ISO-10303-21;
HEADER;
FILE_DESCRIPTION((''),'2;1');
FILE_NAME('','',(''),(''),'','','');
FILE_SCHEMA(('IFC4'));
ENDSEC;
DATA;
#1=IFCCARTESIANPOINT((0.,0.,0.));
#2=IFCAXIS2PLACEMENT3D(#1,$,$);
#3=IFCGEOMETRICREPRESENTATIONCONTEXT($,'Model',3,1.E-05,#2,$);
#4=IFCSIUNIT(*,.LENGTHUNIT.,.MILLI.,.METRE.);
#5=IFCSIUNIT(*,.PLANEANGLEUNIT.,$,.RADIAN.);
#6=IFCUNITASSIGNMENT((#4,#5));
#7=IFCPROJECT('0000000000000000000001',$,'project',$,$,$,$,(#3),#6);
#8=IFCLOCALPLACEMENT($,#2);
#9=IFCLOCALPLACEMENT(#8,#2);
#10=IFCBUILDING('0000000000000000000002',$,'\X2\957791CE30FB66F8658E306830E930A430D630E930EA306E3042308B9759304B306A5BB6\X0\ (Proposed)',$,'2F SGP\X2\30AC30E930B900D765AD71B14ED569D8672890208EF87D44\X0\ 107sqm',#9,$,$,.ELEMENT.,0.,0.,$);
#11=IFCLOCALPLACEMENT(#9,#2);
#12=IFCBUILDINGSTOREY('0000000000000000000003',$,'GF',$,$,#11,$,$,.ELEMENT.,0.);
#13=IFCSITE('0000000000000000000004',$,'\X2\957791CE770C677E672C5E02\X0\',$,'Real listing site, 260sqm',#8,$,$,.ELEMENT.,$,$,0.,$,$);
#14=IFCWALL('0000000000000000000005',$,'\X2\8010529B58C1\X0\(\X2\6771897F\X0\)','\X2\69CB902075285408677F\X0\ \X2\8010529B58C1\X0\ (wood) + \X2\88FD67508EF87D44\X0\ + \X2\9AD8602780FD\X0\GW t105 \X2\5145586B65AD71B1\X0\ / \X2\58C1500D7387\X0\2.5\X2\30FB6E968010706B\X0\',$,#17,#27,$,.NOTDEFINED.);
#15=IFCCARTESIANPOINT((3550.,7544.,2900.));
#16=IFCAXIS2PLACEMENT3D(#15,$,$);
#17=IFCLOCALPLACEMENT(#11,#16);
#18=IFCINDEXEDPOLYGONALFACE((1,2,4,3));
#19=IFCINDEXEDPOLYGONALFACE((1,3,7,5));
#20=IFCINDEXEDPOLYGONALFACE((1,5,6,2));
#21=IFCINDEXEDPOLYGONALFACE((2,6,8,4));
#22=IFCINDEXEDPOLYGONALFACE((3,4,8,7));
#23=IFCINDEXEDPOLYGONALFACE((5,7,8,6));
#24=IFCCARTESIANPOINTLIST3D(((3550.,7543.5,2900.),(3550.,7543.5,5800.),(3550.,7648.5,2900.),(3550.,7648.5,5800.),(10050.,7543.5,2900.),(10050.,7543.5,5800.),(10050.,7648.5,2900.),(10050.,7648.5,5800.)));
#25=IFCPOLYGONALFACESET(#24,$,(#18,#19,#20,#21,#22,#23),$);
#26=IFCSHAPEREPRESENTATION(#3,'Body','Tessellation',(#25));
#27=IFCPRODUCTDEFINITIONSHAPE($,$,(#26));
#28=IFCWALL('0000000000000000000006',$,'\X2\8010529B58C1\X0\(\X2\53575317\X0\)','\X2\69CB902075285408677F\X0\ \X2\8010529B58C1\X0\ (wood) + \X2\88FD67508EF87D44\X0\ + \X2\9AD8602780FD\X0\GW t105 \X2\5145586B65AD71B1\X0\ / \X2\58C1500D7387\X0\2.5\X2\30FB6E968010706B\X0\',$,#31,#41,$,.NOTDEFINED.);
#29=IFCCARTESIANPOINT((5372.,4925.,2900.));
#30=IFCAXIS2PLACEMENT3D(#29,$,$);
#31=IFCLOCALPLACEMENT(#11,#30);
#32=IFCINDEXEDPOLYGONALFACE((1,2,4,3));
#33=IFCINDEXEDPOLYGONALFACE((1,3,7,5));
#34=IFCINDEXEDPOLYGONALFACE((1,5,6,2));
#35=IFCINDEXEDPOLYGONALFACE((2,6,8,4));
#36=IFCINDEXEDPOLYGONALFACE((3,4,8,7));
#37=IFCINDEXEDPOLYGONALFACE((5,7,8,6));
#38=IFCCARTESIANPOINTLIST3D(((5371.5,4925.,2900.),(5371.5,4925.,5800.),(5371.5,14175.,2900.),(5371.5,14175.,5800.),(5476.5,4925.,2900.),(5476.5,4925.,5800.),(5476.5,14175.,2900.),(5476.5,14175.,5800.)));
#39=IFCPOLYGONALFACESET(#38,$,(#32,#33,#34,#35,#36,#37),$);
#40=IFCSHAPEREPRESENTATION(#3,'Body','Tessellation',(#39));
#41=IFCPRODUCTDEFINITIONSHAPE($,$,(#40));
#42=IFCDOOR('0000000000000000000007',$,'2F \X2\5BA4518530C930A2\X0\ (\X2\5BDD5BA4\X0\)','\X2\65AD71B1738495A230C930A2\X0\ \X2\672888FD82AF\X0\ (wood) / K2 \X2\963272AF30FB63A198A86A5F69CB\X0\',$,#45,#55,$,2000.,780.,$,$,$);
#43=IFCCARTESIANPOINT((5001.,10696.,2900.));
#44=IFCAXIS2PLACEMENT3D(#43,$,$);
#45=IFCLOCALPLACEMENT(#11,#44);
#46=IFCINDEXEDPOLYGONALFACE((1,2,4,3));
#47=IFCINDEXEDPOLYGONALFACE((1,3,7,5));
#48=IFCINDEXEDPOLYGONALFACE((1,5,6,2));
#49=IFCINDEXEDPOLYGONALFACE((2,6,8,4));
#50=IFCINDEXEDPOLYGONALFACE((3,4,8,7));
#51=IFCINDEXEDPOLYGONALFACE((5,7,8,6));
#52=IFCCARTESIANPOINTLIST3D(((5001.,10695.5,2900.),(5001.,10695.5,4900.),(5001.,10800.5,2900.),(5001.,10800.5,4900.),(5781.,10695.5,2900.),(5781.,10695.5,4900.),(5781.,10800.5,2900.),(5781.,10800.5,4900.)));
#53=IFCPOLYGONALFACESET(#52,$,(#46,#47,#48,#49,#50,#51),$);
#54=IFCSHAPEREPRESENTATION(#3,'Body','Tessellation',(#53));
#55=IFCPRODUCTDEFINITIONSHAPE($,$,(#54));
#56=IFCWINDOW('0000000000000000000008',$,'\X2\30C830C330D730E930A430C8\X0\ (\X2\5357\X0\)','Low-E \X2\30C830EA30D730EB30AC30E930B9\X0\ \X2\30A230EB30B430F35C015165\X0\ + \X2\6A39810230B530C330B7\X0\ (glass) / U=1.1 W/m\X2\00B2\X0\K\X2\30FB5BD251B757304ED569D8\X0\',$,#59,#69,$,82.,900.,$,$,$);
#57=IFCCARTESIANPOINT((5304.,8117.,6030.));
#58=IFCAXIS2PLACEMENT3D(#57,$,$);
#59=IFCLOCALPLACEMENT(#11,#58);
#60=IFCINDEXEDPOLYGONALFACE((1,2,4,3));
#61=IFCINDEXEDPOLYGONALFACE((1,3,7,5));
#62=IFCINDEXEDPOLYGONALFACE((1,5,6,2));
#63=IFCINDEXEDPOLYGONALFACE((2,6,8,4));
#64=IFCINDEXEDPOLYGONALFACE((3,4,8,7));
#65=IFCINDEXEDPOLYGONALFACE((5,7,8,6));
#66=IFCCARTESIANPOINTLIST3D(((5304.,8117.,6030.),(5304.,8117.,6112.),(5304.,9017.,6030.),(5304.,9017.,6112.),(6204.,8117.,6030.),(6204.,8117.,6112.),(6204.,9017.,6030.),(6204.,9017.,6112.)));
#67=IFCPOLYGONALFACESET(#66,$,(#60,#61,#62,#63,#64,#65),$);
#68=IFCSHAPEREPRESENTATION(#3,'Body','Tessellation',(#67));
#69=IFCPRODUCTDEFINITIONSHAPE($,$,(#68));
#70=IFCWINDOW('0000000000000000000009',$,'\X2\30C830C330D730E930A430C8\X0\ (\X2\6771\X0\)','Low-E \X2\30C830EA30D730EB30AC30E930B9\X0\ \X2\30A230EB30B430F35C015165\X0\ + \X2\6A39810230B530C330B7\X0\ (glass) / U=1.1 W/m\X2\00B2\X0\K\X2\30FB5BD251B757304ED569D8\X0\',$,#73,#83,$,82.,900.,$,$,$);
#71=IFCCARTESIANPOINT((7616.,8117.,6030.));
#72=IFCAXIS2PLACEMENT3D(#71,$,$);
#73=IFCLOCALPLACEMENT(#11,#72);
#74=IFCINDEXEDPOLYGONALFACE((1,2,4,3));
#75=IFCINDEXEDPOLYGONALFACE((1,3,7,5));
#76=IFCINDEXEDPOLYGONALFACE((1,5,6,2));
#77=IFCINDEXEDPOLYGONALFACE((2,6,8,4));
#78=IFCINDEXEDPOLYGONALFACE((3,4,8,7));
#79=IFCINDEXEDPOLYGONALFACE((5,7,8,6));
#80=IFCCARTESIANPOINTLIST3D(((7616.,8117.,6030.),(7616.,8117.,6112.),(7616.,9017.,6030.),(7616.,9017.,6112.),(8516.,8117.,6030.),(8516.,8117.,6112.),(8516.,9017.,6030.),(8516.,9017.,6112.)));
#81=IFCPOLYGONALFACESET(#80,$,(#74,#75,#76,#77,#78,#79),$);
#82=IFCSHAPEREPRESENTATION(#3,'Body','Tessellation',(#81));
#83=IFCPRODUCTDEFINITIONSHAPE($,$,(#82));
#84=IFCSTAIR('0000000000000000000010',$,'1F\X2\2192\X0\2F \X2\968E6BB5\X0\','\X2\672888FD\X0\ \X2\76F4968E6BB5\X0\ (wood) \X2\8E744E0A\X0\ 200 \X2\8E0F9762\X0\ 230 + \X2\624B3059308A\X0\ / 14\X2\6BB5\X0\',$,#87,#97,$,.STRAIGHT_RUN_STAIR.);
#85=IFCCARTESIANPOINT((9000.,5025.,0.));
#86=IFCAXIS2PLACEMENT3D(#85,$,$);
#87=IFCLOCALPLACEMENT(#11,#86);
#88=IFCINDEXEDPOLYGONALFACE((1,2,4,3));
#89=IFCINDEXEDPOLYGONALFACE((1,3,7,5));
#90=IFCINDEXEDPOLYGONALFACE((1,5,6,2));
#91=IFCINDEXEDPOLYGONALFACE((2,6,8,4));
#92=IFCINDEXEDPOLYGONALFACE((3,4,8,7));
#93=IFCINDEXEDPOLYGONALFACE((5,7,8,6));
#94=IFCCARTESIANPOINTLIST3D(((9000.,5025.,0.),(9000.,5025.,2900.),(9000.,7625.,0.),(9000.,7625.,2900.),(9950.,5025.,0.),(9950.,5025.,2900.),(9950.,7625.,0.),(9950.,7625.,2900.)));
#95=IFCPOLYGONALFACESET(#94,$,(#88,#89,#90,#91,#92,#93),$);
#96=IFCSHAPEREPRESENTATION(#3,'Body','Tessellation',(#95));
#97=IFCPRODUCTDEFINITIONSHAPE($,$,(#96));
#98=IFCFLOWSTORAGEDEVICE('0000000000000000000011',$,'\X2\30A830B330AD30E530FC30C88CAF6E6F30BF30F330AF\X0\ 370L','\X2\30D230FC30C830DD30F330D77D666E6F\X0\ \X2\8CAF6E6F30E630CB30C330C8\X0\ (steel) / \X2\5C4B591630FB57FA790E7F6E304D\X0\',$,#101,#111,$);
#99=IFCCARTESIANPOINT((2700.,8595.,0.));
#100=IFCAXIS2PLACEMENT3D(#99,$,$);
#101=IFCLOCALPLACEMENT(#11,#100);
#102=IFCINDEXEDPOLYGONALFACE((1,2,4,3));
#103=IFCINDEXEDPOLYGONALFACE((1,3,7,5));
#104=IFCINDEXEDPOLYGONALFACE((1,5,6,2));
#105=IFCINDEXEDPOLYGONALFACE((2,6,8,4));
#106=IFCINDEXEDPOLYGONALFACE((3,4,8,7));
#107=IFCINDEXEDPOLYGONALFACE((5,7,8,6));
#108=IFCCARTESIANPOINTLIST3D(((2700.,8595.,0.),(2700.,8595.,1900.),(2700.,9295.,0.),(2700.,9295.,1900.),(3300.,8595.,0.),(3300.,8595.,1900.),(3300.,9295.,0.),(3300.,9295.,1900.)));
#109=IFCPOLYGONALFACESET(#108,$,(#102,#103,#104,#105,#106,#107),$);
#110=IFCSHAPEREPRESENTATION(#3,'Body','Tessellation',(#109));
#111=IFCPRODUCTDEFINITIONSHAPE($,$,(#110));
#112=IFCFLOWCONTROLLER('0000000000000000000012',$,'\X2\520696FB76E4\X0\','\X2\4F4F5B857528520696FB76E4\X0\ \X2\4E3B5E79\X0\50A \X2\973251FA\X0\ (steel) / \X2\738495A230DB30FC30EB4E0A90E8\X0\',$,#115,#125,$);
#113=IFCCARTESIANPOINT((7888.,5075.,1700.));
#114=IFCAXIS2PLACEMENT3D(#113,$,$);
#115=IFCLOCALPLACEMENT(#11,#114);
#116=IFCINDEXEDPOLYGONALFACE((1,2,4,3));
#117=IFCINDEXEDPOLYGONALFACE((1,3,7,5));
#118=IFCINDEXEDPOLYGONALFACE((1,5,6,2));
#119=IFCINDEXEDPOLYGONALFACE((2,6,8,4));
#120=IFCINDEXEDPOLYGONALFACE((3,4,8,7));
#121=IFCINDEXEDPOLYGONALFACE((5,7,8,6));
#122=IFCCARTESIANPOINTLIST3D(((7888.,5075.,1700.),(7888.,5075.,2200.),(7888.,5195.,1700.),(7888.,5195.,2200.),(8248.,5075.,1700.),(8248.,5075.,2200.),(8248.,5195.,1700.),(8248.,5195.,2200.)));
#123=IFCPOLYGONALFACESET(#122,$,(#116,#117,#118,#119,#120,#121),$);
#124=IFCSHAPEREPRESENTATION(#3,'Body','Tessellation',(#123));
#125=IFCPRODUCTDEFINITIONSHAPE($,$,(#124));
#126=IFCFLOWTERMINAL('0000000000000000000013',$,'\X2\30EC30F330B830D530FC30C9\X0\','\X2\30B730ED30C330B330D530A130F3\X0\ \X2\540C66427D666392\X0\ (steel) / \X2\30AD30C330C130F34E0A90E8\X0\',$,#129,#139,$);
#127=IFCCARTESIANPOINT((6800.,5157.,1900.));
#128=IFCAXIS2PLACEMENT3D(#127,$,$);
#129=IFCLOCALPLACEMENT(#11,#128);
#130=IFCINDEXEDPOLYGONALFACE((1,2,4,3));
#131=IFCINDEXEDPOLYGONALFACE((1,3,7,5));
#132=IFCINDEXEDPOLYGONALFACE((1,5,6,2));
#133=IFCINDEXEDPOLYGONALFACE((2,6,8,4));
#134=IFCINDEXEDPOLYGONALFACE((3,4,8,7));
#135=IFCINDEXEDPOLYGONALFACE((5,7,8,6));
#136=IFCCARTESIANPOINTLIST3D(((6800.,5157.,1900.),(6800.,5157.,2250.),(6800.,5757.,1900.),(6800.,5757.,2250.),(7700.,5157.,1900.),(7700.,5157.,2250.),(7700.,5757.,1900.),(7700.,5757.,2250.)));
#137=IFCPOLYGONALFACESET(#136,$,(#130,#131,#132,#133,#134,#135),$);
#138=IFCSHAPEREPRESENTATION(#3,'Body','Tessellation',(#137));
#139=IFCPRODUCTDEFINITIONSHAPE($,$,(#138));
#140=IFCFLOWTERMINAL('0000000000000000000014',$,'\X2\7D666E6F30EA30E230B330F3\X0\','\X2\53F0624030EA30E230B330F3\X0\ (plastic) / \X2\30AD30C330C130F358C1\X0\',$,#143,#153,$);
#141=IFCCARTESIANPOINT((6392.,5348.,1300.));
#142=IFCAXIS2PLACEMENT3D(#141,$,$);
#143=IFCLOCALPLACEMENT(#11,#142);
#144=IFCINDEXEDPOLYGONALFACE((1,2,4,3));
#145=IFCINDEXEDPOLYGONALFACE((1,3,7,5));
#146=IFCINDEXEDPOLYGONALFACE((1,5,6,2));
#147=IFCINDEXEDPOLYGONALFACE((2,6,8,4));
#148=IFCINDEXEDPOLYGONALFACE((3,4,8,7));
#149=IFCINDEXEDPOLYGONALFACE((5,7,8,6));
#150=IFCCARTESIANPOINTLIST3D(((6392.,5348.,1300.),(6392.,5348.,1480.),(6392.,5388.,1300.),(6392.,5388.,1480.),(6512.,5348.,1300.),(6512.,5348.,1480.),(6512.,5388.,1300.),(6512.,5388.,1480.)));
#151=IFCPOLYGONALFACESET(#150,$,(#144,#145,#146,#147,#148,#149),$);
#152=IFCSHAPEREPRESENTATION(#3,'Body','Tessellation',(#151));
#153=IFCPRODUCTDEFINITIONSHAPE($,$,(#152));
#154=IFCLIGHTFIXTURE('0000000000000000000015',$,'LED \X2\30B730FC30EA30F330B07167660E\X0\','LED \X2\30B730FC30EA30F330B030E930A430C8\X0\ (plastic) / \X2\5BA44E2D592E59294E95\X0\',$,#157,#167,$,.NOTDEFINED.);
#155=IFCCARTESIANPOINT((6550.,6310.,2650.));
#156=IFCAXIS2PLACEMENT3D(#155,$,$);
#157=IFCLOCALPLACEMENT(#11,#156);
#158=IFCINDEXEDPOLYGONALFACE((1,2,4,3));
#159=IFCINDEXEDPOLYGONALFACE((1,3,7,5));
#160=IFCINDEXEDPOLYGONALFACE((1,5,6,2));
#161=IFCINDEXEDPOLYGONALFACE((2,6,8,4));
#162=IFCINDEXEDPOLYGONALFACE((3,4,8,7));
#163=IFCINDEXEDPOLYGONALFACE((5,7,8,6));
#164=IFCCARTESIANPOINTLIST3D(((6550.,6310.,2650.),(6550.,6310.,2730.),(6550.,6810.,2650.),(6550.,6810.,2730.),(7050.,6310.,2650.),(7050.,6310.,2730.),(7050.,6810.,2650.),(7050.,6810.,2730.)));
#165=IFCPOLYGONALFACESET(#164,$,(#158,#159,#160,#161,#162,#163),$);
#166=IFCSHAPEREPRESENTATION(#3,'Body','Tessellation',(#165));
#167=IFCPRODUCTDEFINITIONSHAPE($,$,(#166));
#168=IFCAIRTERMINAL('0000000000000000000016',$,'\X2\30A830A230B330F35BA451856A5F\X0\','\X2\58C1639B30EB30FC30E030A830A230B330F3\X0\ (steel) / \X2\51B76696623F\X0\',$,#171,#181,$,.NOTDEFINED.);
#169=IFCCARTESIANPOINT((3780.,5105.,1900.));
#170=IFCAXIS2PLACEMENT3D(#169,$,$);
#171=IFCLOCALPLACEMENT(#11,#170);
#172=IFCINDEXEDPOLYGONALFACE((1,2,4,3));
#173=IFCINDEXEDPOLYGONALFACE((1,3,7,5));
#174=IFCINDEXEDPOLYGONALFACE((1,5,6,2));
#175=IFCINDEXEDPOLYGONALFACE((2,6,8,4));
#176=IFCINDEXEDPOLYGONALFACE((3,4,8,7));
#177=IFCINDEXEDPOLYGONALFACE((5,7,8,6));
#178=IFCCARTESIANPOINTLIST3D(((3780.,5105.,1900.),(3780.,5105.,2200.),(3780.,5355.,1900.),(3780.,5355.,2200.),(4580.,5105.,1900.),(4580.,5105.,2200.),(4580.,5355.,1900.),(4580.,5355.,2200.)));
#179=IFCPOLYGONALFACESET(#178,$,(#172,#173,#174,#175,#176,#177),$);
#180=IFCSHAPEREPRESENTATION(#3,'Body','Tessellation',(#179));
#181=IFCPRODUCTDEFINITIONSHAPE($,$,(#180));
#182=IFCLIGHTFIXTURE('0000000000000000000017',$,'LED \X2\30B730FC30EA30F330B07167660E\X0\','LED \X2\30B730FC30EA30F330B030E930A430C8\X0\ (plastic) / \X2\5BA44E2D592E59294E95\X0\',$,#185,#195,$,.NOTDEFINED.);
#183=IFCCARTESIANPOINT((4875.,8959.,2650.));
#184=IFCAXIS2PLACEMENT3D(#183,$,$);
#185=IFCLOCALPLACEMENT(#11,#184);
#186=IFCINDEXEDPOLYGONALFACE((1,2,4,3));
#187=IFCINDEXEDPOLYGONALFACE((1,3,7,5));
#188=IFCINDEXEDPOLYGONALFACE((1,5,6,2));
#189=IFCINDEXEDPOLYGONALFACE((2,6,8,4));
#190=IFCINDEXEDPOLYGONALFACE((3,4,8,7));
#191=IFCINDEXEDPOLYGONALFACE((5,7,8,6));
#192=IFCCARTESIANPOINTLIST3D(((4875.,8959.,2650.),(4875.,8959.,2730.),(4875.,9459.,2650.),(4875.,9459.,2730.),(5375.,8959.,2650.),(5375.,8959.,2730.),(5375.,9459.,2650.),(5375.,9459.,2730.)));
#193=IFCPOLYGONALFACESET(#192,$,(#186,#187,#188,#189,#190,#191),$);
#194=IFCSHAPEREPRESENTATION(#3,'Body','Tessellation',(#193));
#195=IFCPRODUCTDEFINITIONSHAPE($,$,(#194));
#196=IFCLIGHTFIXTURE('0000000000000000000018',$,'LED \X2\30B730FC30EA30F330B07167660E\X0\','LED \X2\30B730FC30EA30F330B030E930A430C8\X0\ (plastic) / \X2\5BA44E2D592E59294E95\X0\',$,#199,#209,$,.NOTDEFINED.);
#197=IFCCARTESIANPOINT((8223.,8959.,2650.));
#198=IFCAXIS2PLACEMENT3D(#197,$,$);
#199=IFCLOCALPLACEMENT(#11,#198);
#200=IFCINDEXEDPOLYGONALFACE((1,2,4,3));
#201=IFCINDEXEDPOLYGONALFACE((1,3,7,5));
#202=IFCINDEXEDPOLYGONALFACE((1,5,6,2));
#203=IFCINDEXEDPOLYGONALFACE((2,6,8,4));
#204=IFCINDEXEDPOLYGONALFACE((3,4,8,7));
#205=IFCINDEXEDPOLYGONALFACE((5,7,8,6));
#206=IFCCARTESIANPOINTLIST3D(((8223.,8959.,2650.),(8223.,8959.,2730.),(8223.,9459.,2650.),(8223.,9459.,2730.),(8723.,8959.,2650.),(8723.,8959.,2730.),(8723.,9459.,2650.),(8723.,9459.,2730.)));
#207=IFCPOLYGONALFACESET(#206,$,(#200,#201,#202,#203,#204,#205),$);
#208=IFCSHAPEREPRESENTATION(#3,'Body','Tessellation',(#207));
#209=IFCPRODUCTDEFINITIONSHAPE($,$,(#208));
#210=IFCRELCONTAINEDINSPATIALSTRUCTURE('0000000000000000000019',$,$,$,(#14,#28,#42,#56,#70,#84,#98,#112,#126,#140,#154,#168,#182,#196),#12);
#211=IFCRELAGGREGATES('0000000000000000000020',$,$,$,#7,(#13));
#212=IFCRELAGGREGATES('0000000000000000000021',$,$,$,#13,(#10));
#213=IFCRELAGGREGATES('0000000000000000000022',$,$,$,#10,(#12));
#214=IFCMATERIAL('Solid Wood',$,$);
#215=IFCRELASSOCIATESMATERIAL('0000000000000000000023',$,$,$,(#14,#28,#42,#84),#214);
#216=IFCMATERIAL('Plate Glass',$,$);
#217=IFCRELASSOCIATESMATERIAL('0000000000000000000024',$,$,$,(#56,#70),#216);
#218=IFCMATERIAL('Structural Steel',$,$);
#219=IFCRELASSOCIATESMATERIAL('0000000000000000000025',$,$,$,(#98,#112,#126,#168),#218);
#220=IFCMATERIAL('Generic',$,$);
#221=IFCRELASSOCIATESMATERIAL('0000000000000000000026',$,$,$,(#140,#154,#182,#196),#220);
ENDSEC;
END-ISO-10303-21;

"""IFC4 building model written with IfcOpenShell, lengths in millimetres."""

from ifc_helpers import new_model, si_unit, frame, frame_2d, origin, place, context, project, spatial, rectangle, extrude, material, element, fill, save


model = new_model("IFC4")

# Units and contexts
model_context = context("Model", 3, precision=1e-05, world=origin())
ifc_project = project(units=[si_unit("LENGTHUNIT", "METRE", prefix="MILLI"), si_unit("PLANEANGLEUNIT", "RADIAN")], contexts=[model_context])

# Site, building, storey
site_placement = place(None, origin())
site = spatial("IfcSite", under=ifc_project, at=site_placement, Name="長野県松本市", ObjectType="Real listing site, 260sqm", CompositionType="ELEMENT", RefElevation=0.0)
building_placement = place(site_placement, origin())
building = spatial("IfcBuilding", under=site, at=building_placement, Name="長野・書斎とライブラリのある静かな家 (Proposed)", ObjectType="2F SGPガラス×断熱仕様木造軸組 107sqm", CompositionType="ELEMENT", ElevationOfRefHeight=0.0, ElevationOfTerrain=0.0)
storey_placement = place(building_placement, origin())
storey = spatial("IfcBuildingStorey", under=building, at=storey_placement, Name="GF", CompositionType="ELEMENT", Elevation=0.0)

# Shared definitions
ifc_material_1 = material(Name="Solid Wood")

# Wall
wall_1_placement = place(storey_placement, frame((3550.0, 7544.0, 2900.0)))
element("IfcWall", 1, at=wall_1_placement, inside=storey, material=ifc_material_1, Name="耐力壁(東西)", Description="構造用合板 耐力壁 (wood) + 製材軸組 + 高性能GW t105 充填断熱 / 壁倍率2.5・準耐火", PredefinedType="NOTDEFINED", context=model_context, shape_type="SweptSolid", body=[
    extrude(rectangle(XDim=6500.0, YDim=105.0, at=frame_2d((3250.0, 52.0))), frame((3550.0, 7544.0, 2900.0)), (0.0, 0.0, 1.0), 2900.0),
])

# Wall, opening, door
wall_2_placement = place(storey_placement, frame((5372.0, 4925.0, 2900.0)))
wall_2 = element("IfcWall", 2, at=wall_2_placement, inside=storey, material=ifc_material_1, Name="耐力壁(南北)", Description="構造用合板 耐力壁 (wood) + 製材軸組 + 高性能GW t105 充填断熱 / 壁倍率2.5・準耐火", PredefinedType="NOTDEFINED", context=model_context, shape_type="SweptSolid", body=[
    extrude(rectangle(XDim=105.0, YDim=9250.0, at=frame_2d((52.0, 4625.0))), frame((5372.0, 4925.0, 2900.0)), (0.0, 0.0, 1.0), 2900.0),
])
opening_placement = place(storey_placement, frame((5001.0, 10696.0, 2900.0)))
opening = element("IfcOpeningElement", 3, at=opening_placement, cuts=wall_2, PredefinedType="NOTDEFINED", context=model_context, shape_type="SweptSolid", body=[
    extrude(rectangle(XDim=780.0, YDim=105.0, at=frame_2d((390.0, 52.0))), frame((5001.0, 10696.0, 2900.0)), (0.0, 0.0, 1.0), 2000.0),
])
door_placement = place(storey_placement, frame((5001.0, 10696.0, 2900.0)))
door = element("IfcDoor", 4, at=door_placement, inside=storey, material=ifc_material_1, Name="2F 室内ドア (寝室)", Description="断熱玄関ドア 木製芯 (wood) / K2 防犯・採風機構", OverallHeight=2000.0, OverallWidth=780.0, context=model_context, shape_type="SweptSolid", body=[
    extrude(rectangle(XDim=780.0, YDim=105.0, at=frame_2d((390.0, 52.0))), frame((5001.0, 10696.0, 2900.0)), (0.0, 0.0, 1.0), 2000.0),
])
fill(opening, door)

# Windows
ifc_material_2 = material(Name="Plate Glass")
window_1_placement = place(storey_placement, frame((5304.0, 8117.0, 6030.0)))
element("IfcWindow", 5, at=window_1_placement, inside=storey, material=ifc_material_2, Name="トップライト (南)", Description="Low-E トリプルガラス アルゴン封入 + 樹脂サッシ (glass) / U=1.1 W/m²K・寒冷地仕様", OverallHeight=82.0, OverallWidth=900.0, context=model_context, shape_type="SweptSolid", body=[
    extrude(rectangle(XDim=900.0, YDim=900.0, at=frame_2d((450.0, 450.0))), frame((5304.0, 8117.0, 6030.0)), (0.0, 0.0, 1.0), 82.0),
])
window_2_placement = place(storey_placement, frame((7616.0, 8117.0, 6030.0)))
element("IfcWindow", 6, at=window_2_placement, inside=storey, material=ifc_material_2, Name="トップライト (東)", Description="Low-E トリプルガラス アルゴン封入 + 樹脂サッシ (glass) / U=1.1 W/m²K・寒冷地仕様", OverallHeight=82.0, OverallWidth=900.0, context=model_context, shape_type="SweptSolid", body=[
    extrude(rectangle(XDim=900.0, YDim=900.0, at=frame_2d((450.0, 450.0))), frame((7616.0, 8117.0, 6030.0)), (0.0, 0.0, 1.0), 82.0),
])

# Stair
stair_placement = place(storey_placement, frame((9000.0, 5025.0, 0.0)))
element("IfcStair", 7, at=stair_placement, inside=storey, material=ifc_material_1, Name="1F→2F 階段", Description="木製 直階段 (wood) 蹴上 200 踏面 230 + 手すり / 14段", PredefinedType="STRAIGHT_RUN_STAIR", context=model_context, shape_type="SweptSolid", body=[
    extrude(rectangle(XDim=950.0, YDim=2600.0, at=frame_2d((475.0, 1300.0))), frame((9000.0, 5025.0, 0.0)), (0.0, 0.0, 1.0), 2900.0),
])

# Flow storage device
ifc_material_3 = material(Name="Structural Steel")
flow_storage_device_placement = place(storey_placement, frame((2700.0, 8595.0, 0.0)))
element("IfcFlowStorageDevice", 8, at=flow_storage_device_placement, inside=storey, material=ifc_material_3, Name="エコキュート貯湯タンク 370L", Description="ヒートポンプ給湯 貯湯ユニット (steel) / 屋外・基礎置き", context=model_context, shape_type="SweptSolid", body=[
    extrude(rectangle(XDim=600.0, YDim=700.0, at=frame_2d((300.0, 350.0))), frame((2700.0, 8595.0, 0.0)), (0.0, 0.0, 1.0), 1900.0),
])

# Flow controller
flow_controller_placement = place(storey_placement, frame((7888.0, 5075.0, 1700.0)))
element("IfcFlowController", 9, at=flow_controller_placement, inside=storey, material=ifc_material_3, Name="分電盤", Description="住宅用分電盤 主幹50A 露出 (steel) / 玄関ホール上部", context=model_context, shape_type="SweptSolid", body=[
    extrude(rectangle(XDim=360.0, YDim=120.0, at=frame_2d((180.0, 60.0))), frame((7888.0, 5075.0, 1700.0)), (0.0, 0.0, 1.0), 500.0),
])

# Flow terminals
flow_terminal_1_placement = place(storey_placement, frame((6800.0, 5157.0, 1900.0)))
element("IfcFlowTerminal", 10, at=flow_terminal_1_placement, inside=storey, material=ifc_material_3, Name="レンジフード", Description="シロッコファン 同時給排 (steel) / キッチン上部", context=model_context, shape_type="SweptSolid", body=[
    extrude(rectangle(XDim=900.0, YDim=600.0, at=frame_2d((450.0, 300.0))), frame((6800.0, 5157.0, 1900.0)), (0.0, 0.0, 1.0), 350.0),
])
ifc_material_4 = material(Name="Generic")
flow_terminal_2_placement = place(storey_placement, frame((6392.0, 5348.0, 1300.0)))
element("IfcFlowTerminal", 11, at=flow_terminal_2_placement, inside=storey, material=ifc_material_4, Name="給湯リモコン", Description="台所リモコン (plastic) / キッチン壁", context=model_context, shape_type="SweptSolid", body=[
    extrude(rectangle(XDim=120.0, YDim=40.0, at=frame_2d((60.0, 20.0))), frame((6392.0, 5348.0, 1300.0)), (0.0, 0.0, 1.0), 180.0),
])

# Light fixture
light_fixture_1_placement = place(storey_placement, frame((6550.0, 6310.0, 2650.0)))
element("IfcLightFixture", 12, at=light_fixture_1_placement, inside=storey, material=ifc_material_4, Name="LED シーリング照明", Description="LED シーリングライト (plastic) / 室中央天井", PredefinedType="NOTDEFINED", context=model_context, shape_type="SweptSolid", body=[
    extrude(rectangle(XDim=500.0, YDim=500.0, at=frame_2d((250.0, 250.0))), frame((6550.0, 6310.0, 2650.0)), (0.0, 0.0, 1.0), 80.0),
])

# Air terminal
air_terminal_1_placement = place(storey_placement, frame((3780.0, 5105.0, 1900.0)))
element("IfcAirTerminal", 13, at=air_terminal_1_placement, inside=storey, material=ifc_material_3, Name="エアコン室内機", Description="壁掛ルームエアコン (steel) / 冷暖房", PredefinedType="NOTDEFINED", context=model_context, shape_type="SweptSolid", body=[
    extrude(rectangle(XDim=800.0, YDim=250.0, at=frame_2d((400.0, 125.0))), frame((3780.0, 5105.0, 1900.0)), (0.0, 0.0, 1.0), 300.0),
])

# Light fixtures
light_fixture_2_placement = place(storey_placement, frame((4875.0, 8959.0, 2650.0)))
element("IfcLightFixture", 14, at=light_fixture_2_placement, inside=storey, material=ifc_material_4, Name="LED シーリング照明", Description="LED シーリングライト (plastic) / 室中央天井", PredefinedType="NOTDEFINED", context=model_context, shape_type="SweptSolid", body=[
    extrude(rectangle(XDim=500.0, YDim=500.0, at=frame_2d((250.0, 250.0))), frame((4875.0, 8959.0, 2650.0)), (0.0, 0.0, 1.0), 80.0),
])
light_fixture_3_placement = place(storey_placement, frame((8223.0, 8959.0, 2650.0)))
element("IfcLightFixture", 15, at=light_fixture_3_placement, inside=storey, material=ifc_material_4, Name="LED シーリング照明", Description="LED シーリングライト (plastic) / 室中央天井", PredefinedType="NOTDEFINED", context=model_context, shape_type="SweptSolid", body=[
    extrude(rectangle(XDim=500.0, YDim=500.0, at=frame_2d((250.0, 250.0))), frame((8223.0, 8959.0, 2650.0)), (0.0, 0.0, 1.0), 80.0),
])

save(model, "model.ifc")
